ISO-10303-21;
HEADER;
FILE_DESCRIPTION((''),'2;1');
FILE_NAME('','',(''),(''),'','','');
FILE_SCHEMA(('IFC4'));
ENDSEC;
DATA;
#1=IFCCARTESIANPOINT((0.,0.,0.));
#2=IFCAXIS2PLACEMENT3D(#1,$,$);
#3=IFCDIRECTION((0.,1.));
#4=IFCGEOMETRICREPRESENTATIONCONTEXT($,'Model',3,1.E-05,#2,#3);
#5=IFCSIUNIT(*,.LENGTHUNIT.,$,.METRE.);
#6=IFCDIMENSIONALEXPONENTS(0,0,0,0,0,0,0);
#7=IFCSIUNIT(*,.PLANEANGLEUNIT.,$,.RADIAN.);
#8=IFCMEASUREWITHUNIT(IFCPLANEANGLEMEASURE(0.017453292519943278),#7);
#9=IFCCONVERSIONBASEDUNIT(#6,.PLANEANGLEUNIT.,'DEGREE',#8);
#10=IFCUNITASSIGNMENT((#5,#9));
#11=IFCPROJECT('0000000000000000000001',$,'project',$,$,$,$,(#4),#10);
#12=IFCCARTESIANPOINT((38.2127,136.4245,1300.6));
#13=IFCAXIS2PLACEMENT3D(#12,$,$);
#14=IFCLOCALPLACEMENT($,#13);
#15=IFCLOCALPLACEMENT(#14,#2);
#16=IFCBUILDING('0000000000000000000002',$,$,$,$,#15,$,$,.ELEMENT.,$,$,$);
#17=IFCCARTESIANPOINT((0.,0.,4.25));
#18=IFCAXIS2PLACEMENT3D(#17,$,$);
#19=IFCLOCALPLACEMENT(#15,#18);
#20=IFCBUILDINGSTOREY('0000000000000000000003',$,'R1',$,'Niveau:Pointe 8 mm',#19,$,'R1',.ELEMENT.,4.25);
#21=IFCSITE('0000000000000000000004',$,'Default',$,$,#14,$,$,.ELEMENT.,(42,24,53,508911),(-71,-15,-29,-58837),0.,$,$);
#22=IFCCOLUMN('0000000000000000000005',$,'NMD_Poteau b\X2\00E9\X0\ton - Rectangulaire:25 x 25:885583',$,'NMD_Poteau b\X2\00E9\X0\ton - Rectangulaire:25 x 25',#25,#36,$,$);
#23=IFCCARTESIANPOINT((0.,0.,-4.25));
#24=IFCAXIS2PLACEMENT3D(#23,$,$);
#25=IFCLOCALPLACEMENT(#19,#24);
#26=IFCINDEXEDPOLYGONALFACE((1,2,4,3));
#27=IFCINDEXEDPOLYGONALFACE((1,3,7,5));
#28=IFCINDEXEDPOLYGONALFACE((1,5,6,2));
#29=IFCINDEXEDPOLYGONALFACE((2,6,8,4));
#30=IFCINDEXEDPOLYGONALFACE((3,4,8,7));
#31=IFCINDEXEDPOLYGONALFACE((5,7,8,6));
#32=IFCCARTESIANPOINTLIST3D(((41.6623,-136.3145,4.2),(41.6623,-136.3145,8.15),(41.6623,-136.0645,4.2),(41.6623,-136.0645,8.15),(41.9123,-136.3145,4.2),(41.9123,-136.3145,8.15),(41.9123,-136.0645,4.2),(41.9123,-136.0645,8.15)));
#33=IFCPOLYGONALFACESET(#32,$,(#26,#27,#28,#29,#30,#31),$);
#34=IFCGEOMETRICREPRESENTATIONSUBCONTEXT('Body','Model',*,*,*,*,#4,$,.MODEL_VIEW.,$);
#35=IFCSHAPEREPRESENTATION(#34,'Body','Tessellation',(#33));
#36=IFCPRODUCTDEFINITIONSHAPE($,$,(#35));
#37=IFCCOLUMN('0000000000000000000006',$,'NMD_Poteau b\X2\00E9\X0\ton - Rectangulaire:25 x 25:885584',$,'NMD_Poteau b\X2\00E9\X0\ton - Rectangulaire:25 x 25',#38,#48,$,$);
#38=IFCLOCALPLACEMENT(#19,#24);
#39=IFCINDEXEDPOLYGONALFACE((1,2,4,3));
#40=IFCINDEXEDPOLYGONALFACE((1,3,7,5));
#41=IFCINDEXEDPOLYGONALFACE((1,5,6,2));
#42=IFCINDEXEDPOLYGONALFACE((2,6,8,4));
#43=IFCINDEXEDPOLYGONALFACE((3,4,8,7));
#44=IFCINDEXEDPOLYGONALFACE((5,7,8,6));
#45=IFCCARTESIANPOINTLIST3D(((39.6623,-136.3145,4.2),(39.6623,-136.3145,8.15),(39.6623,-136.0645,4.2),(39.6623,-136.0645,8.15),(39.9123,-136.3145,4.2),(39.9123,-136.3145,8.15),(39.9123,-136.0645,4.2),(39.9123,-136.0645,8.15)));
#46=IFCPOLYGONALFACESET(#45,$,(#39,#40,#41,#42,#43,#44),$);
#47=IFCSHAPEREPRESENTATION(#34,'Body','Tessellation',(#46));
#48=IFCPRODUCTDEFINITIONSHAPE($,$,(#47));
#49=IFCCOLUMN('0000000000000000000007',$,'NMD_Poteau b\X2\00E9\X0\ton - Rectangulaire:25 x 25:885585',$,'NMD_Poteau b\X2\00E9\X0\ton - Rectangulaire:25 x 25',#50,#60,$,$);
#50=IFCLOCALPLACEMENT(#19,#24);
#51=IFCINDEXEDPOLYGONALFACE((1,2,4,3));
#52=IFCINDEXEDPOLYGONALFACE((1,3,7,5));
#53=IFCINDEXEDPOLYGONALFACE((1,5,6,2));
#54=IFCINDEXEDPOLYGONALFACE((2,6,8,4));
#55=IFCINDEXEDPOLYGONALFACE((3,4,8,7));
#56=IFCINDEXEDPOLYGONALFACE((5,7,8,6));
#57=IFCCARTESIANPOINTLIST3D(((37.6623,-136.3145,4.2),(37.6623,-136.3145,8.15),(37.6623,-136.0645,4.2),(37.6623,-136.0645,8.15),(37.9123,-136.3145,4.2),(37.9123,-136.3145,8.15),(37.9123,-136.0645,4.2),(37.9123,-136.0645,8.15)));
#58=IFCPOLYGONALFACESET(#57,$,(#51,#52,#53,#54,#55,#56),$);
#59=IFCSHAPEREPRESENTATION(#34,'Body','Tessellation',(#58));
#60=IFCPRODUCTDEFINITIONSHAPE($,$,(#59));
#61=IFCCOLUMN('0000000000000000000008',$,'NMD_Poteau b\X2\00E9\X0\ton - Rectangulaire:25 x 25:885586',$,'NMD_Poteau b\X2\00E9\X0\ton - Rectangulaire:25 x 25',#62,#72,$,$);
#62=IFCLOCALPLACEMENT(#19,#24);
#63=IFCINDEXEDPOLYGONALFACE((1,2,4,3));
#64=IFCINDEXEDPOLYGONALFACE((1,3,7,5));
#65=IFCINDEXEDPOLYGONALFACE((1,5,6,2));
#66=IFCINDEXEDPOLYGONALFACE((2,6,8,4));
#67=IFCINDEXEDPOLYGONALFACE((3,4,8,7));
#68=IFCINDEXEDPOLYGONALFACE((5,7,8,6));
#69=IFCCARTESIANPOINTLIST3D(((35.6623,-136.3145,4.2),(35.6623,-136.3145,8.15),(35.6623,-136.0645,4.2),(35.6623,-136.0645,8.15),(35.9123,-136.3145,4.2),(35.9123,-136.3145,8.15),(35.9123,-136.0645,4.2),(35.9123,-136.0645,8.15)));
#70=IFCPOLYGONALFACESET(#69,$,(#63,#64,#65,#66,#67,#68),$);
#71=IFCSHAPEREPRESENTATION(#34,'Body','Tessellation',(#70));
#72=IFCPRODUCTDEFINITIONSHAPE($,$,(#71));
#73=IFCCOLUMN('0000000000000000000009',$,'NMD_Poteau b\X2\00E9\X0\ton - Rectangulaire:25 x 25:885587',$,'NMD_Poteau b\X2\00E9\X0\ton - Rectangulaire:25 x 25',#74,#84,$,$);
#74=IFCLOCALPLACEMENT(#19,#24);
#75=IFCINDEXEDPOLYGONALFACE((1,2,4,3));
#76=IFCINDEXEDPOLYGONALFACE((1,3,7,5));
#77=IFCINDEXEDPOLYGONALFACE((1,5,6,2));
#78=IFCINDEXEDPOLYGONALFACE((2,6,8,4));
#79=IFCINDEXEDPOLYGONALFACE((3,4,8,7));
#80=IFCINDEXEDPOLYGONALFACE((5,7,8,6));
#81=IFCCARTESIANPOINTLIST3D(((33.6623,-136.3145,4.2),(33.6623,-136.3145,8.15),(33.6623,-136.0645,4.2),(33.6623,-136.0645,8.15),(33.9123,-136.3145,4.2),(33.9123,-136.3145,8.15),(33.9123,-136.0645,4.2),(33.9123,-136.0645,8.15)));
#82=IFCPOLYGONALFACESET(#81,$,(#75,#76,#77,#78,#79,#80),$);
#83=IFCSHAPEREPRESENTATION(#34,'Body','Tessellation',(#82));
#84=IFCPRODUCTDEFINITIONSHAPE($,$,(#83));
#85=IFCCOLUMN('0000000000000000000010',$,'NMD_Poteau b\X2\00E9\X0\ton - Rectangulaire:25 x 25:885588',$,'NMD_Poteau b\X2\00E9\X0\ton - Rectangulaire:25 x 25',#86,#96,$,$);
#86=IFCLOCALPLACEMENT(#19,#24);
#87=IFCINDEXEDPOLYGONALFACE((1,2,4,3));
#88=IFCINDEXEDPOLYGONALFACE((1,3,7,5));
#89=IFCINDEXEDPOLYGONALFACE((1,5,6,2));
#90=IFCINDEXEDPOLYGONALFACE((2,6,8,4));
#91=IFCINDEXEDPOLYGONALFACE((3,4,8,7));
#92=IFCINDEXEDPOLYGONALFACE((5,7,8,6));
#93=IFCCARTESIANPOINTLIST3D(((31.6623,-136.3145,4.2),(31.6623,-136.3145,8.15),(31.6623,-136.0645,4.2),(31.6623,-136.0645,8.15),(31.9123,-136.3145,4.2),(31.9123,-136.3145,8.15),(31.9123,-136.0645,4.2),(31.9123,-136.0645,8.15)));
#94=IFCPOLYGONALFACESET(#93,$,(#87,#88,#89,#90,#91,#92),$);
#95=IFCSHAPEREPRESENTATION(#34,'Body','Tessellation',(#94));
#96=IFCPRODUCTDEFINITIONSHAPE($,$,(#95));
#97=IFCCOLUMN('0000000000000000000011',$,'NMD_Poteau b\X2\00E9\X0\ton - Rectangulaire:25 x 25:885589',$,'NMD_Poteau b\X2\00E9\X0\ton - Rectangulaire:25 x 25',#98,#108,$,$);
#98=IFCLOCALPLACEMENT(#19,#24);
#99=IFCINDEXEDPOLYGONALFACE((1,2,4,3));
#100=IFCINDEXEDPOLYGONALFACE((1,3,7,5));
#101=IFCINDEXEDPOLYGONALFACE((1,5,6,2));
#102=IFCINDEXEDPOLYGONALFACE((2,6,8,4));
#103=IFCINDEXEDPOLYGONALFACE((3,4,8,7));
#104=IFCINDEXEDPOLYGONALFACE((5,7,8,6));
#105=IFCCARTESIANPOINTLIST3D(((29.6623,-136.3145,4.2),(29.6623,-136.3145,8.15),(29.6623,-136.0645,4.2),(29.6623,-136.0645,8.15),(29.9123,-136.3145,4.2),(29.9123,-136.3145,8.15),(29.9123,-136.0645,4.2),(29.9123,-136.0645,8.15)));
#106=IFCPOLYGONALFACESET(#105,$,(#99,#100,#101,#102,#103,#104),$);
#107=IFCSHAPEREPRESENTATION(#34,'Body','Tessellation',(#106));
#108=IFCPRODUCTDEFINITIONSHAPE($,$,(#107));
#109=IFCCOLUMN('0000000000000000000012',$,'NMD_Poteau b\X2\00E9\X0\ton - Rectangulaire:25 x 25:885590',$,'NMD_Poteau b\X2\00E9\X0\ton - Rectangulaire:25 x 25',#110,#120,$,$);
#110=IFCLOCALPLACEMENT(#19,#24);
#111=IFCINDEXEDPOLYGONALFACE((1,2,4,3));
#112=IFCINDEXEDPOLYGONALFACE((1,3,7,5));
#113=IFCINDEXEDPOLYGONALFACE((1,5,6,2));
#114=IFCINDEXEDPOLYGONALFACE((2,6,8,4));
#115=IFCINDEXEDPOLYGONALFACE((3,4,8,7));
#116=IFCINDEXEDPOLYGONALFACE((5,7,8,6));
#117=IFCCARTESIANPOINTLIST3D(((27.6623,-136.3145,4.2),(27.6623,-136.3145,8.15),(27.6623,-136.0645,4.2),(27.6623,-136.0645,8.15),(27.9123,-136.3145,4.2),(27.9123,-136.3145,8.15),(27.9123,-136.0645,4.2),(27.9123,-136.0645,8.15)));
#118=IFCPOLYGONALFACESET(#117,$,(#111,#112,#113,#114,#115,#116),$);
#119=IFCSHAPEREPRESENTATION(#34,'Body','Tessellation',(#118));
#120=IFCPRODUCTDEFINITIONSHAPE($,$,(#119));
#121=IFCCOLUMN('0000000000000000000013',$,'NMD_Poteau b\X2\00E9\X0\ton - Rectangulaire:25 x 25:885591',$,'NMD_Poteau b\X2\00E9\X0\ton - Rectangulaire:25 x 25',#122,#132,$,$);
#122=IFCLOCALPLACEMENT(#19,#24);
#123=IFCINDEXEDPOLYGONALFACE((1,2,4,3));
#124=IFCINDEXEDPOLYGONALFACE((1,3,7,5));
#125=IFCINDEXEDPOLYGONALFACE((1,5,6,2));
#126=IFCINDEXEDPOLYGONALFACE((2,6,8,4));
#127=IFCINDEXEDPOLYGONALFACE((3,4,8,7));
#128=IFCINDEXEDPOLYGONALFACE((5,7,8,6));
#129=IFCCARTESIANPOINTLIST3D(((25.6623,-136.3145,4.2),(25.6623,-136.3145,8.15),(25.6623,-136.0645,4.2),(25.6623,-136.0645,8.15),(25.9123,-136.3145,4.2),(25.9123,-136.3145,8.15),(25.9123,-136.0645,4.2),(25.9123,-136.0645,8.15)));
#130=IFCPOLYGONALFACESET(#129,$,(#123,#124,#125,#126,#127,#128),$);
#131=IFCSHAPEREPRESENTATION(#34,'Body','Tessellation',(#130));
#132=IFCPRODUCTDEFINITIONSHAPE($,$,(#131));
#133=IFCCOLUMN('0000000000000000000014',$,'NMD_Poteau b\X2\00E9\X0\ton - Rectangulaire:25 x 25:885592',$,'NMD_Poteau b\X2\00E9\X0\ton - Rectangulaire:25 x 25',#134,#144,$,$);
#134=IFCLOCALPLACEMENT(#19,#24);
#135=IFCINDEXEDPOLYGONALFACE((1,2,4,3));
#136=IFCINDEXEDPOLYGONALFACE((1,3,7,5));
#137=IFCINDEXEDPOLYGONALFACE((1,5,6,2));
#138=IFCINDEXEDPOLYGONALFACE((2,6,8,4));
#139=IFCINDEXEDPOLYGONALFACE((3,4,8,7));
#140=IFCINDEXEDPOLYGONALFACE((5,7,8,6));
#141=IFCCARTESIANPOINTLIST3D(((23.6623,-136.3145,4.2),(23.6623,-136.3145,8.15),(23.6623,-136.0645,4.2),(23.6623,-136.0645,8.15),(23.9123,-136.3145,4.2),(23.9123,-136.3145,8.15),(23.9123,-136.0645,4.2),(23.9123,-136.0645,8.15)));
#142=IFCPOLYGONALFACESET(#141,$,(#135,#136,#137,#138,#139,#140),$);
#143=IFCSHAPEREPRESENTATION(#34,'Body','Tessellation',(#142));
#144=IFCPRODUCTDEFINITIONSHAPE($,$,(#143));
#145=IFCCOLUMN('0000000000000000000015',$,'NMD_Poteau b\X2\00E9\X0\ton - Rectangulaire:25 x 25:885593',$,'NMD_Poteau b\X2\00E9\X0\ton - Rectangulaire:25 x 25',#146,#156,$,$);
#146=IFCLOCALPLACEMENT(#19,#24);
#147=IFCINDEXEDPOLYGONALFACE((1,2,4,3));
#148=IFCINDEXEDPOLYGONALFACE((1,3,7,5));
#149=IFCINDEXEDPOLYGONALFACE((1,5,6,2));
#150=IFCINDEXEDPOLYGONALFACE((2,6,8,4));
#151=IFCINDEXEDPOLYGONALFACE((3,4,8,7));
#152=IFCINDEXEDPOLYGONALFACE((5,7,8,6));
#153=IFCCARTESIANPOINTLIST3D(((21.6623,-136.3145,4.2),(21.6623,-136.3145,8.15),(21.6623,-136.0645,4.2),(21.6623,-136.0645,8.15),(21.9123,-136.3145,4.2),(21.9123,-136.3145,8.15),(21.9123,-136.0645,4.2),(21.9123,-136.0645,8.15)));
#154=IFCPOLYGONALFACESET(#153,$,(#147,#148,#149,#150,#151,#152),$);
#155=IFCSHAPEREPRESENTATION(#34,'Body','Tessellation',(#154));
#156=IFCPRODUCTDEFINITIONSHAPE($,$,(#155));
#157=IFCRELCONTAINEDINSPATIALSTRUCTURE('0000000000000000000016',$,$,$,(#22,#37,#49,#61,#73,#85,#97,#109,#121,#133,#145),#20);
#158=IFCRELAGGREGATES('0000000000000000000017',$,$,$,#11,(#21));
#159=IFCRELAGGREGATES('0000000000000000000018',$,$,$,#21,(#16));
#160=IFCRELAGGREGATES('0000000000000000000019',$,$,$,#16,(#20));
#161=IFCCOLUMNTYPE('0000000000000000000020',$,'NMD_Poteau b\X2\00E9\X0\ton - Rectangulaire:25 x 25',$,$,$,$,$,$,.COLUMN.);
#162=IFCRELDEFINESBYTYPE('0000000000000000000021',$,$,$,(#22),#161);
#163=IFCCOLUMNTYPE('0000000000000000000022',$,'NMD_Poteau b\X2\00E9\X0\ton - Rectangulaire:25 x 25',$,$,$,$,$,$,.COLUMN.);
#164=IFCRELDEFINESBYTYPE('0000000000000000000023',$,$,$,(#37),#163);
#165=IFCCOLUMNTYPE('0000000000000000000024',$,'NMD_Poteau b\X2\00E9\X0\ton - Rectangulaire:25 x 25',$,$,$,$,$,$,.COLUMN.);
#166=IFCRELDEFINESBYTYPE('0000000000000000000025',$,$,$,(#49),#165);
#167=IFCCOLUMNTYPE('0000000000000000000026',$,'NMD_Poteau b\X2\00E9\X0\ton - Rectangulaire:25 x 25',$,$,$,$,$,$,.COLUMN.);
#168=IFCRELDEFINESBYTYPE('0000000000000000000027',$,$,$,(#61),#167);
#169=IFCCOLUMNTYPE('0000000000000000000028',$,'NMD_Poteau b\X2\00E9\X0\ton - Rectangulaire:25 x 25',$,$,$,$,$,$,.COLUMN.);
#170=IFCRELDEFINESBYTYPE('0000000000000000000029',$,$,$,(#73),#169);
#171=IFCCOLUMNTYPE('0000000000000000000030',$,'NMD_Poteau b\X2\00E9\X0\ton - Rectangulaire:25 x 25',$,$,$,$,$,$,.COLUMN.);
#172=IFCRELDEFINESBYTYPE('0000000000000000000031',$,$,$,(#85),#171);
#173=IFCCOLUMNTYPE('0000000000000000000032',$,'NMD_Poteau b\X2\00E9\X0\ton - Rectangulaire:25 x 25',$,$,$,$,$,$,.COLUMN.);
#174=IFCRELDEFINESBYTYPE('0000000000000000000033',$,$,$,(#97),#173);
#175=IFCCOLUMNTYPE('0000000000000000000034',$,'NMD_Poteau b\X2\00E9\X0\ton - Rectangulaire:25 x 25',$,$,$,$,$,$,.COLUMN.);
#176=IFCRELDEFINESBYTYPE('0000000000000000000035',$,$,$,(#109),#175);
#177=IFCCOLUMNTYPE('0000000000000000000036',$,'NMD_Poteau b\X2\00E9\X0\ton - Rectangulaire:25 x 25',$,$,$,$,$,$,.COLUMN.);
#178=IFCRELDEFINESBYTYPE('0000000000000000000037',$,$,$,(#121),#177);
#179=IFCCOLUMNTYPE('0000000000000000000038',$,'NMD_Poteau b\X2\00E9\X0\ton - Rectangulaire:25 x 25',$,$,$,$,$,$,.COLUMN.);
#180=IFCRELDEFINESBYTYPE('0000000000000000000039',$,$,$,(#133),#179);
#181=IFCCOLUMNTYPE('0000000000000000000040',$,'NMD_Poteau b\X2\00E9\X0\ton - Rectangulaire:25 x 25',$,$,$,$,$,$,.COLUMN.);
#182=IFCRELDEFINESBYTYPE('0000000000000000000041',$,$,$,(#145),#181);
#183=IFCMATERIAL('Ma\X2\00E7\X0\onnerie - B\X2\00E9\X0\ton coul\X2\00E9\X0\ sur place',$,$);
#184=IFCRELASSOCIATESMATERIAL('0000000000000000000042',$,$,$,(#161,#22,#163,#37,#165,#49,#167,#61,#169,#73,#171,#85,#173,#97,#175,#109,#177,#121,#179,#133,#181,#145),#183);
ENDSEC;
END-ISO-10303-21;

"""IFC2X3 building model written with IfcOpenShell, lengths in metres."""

from ifc_helpers import new_model, entity, si_unit, converted_unit, direction, frame, frame_2d, origin, place, context, subcontext, project, spatial, rectangle, extrude, source, transform, mapped, material, type_object, type_shapes, element, save


model = new_model("IFC2X3")

# Units and contexts
model_context = context("Model", 3, precision=1e-05, world=origin(), true_north=direction((0.0, 1.0)))
body_context = subcontext(model_context, "Body", "Model", "MODEL_VIEW")
ifc_project = project(units=[si_unit("LENGTHUNIT", "METRE"), converted_unit("PLANEANGLEUNIT", "DEGREE", entity("IfcPlaneAngleMeasure", 0.017453292519943278), si_unit("PLANEANGLEUNIT", "RADIAN"), dimensions=[0, 0, 0, 0, 0, 0, 0])], contexts=[model_context])

# Site, building, storey
site_placement = place(None, frame((38.2127, 136.4245, 1300.6)))
site = spatial("IfcSite", under=ifc_project, at=site_placement, Name="Default", CompositionType="ELEMENT", RefLatitude=(42, 24, 53, 508911), RefLongitude=(-71, -15, -29, -58837), RefElevation=0.0)
building_placement = place(site_placement, origin())
building = spatial("IfcBuilding", under=site, at=building_placement, CompositionType="ELEMENT")
storey_placement = place(building_placement, frame((0.0, 0.0, 4.25)))
storey = spatial("IfcBuildingStorey", under=building, at=storey_placement, Name="R1", ObjectType="Niveau:Pointe 8 mm", LongName="R1", CompositionType="ELEMENT", Elevation=4.25)

# Columns
ifc_material = material(Name="Maçonnerie - Béton coulé sur place")
column_type_1 = type_object("IfcColumnType", Name="NMD_Poteau béton - Rectangulaire:25 x 25", PredefinedType="COLUMN", material=ifc_material)
shared_shape_1 = source(origin(), body_context, "Body", "SweptSolid", [
    extrude(rectangle(XDim=0.25, YDim=0.25, at=frame_2d((0.0, 0.0), x_axis=(1.0, 0.0))), frame((41.7873, -136.1895, 4.2), z_axis=(0.0, 0.0, 1.0), x_axis=(-1.0, 0.0, 0.0)), (0.0, 0.0, 1.0), 3.95),
])
type_shapes(column_type_1, [shared_shape_1])
column_1_placement = place(storey_placement, frame((0.0, 0.0, -4.25)))
element("IfcColumn", 1, at=column_1_placement, inside=storey, type_object=column_type_1, material=ifc_material, Name="NMD_Poteau béton - Rectangulaire:25 x 25:885583", ObjectType="NMD_Poteau béton - Rectangulaire:25 x 25", context=body_context, shape_type="MappedRepresentation", body=[
    mapped(shared_shape_1, transform((0.0, 0.0, 0.0), scale=1.0)),
])
column_type_2 = type_object("IfcColumnType", Name="NMD_Poteau béton - Rectangulaire:25 x 25", PredefinedType="COLUMN", material=ifc_material)
shared_shape_2 = source(origin(), body_context, "Body", "SweptSolid", [
    extrude(rectangle(XDim=0.25, YDim=0.25, at=frame_2d((0.0, 0.0), x_axis=(1.0, 0.0))), frame((39.7873, -136.1895, 4.2), z_axis=(0.0, 0.0, 1.0), x_axis=(-1.0, 0.0, 0.0)), (0.0, 0.0, 1.0), 3.95),
])
type_shapes(column_type_2, [shared_shape_2])
column_2_placement = place(storey_placement, frame((0.0, 0.0, -4.25)))
element("IfcColumn", 2, at=column_2_placement, inside=storey, type_object=column_type_2, material=ifc_material, Name="NMD_Poteau béton - Rectangulaire:25 x 25:885584", ObjectType="NMD_Poteau béton - Rectangulaire:25 x 25", context=body_context, shape_type="MappedRepresentation", body=[
    mapped(shared_shape_2, transform((0.0, 0.0, 0.0), scale=1.0)),
])
column_type_3 = type_object("IfcColumnType", Name="NMD_Poteau béton - Rectangulaire:25 x 25", PredefinedType="COLUMN", material=ifc_material)
shared_shape_3 = source(origin(), body_context, "Body", "SweptSolid", [
    extrude(rectangle(XDim=0.25, YDim=0.25, at=frame_2d((0.0, 0.0), x_axis=(1.0, 0.0))), frame((37.7873, -136.1895, 4.2), z_axis=(0.0, 0.0, 1.0), x_axis=(-1.0, 0.0, 0.0)), (0.0, 0.0, 1.0), 3.95),
])
type_shapes(column_type_3, [shared_shape_3])
column_3_placement = place(storey_placement, frame((0.0, 0.0, -4.25)))
element("IfcColumn", 3, at=column_3_placement, inside=storey, type_object=column_type_3, material=ifc_material, Name="NMD_Poteau béton - Rectangulaire:25 x 25:885585", ObjectType="NMD_Poteau béton - Rectangulaire:25 x 25", context=body_context, shape_type="MappedRepresentation", body=[
    mapped(shared_shape_3, transform((0.0, 0.0, 0.0), scale=1.0)),
])
column_type_4 = type_object("IfcColumnType", Name="NMD_Poteau béton - Rectangulaire:25 x 25", PredefinedType="COLUMN", material=ifc_material)
shared_shape_4 = source(origin(), body_context, "Body", "SweptSolid", [
    extrude(rectangle(XDim=0.25, YDim=0.25, at=frame_2d((0.0, 0.0), x_axis=(1.0, 0.0))), frame((35.7873, -136.1895, 4.2), z_axis=(0.0, 0.0, 1.0), x_axis=(-1.0, 0.0, 0.0)), (0.0, 0.0, 1.0), 3.95),
])
type_shapes(column_type_4, [shared_shape_4])
column_4_placement = place(storey_placement, frame((0.0, 0.0, -4.25)))
element("IfcColumn", 4, at=column_4_placement, inside=storey, type_object=column_type_4, material=ifc_material, Name="NMD_Poteau béton - Rectangulaire:25 x 25:885586", ObjectType="NMD_Poteau béton - Rectangulaire:25 x 25", context=body_context, shape_type="MappedRepresentation", body=[
    mapped(shared_shape_4, transform((0.0, 0.0, 0.0), scale=1.0)),
])
column_type_5 = type_object("IfcColumnType", Name="NMD_Poteau béton - Rectangulaire:25 x 25", PredefinedType="COLUMN", material=ifc_material)
shared_shape_5 = source(origin(), body_context, "Body", "SweptSolid", [
    extrude(rectangle(XDim=0.25, YDim=0.25, at=frame_2d((0.0, 0.0), x_axis=(1.0, 0.0))), frame((33.7873, -136.1895, 4.2), z_axis=(0.0, 0.0, 1.0), x_axis=(-1.0, 0.0, 0.0)), (0.0, 0.0, 1.0), 3.95),
])
type_shapes(column_type_5, [shared_shape_5])
column_5_placement = place(storey_placement, frame((0.0, 0.0, -4.25)))
element("IfcColumn", 5, at=column_5_placement, inside=storey, type_object=column_type_5, material=ifc_material, Name="NMD_Poteau béton - Rectangulaire:25 x 25:885587", ObjectType="NMD_Poteau béton - Rectangulaire:25 x 25", context=body_context, shape_type="MappedRepresentation", body=[
    mapped(shared_shape_5, transform((0.0, 0.0, 0.0), scale=1.0)),
])
column_type_6 = type_object("IfcColumnType", Name="NMD_Poteau béton - Rectangulaire:25 x 25", PredefinedType="COLUMN", material=ifc_material)
shared_shape_6 = source(origin(), body_context, "Body", "SweptSolid", [
    extrude(rectangle(XDim=0.25, YDim=0.25, at=frame_2d((0.0, 0.0), x_axis=(1.0, 0.0))), frame((31.7873, -136.1895, 4.2), z_axis=(0.0, 0.0, 1.0), x_axis=(-1.0, 0.0, 0.0)), (0.0, 0.0, 1.0), 3.95),
])
type_shapes(column_type_6, [shared_shape_6])
column_6_placement = place(storey_placement, frame((0.0, 0.0, -4.25)))
element("IfcColumn", 6, at=column_6_placement, inside=storey, type_object=column_type_6, material=ifc_material, Name="NMD_Poteau béton - Rectangulaire:25 x 25:885588", ObjectType="NMD_Poteau béton - Rectangulaire:25 x 25", context=body_context, shape_type="MappedRepresentation", body=[
    mapped(shared_shape_6, transform((0.0, 0.0, 0.0), scale=1.0)),
])
column_type_7 = type_object("IfcColumnType", Name="NMD_Poteau béton - Rectangulaire:25 x 25", PredefinedType="COLUMN", material=ifc_material)
shared_shape_7 = source(origin(), body_context, "Body", "SweptSolid", [
    extrude(rectangle(XDim=0.25, YDim=0.25, at=frame_2d((0.0, 0.0), x_axis=(1.0, 0.0))), frame((29.7873, -136.1895, 4.2), z_axis=(0.0, 0.0, 1.0), x_axis=(-1.0, 0.0, 0.0)), (0.0, 0.0, 1.0), 3.95),
])
type_shapes(column_type_7, [shared_shape_7])
column_7_placement = place(storey_placement, frame((0.0, 0.0, -4.25)))
element("IfcColumn", 7, at=column_7_placement, inside=storey, type_object=column_type_7, material=ifc_material, Name="NMD_Poteau béton - Rectangulaire:25 x 25:885589", ObjectType="NMD_Poteau béton - Rectangulaire:25 x 25", context=body_context, shape_type="MappedRepresentation", body=[
    mapped(shared_shape_7, transform((0.0, 0.0, 0.0), scale=1.0)),
])
column_type_8 = type_object("IfcColumnType", Name="NMD_Poteau béton - Rectangulaire:25 x 25", PredefinedType="COLUMN", material=ifc_material)
shared_shape_8 = source(origin(), body_context, "Body", "SweptSolid", [
    extrude(rectangle(XDim=0.25, YDim=0.25, at=frame_2d((0.0, 0.0), x_axis=(1.0, 0.0))), frame((27.7873, -136.1895, 4.2), z_axis=(0.0, 0.0, 1.0), x_axis=(-1.0, 0.0, 0.0)), (0.0, 0.0, 1.0), 3.95),
])
type_shapes(column_type_8, [shared_shape_8])
column_8_placement = place(storey_placement, frame((0.0, 0.0, -4.25)))
element("IfcColumn", 8, at=column_8_placement, inside=storey, type_object=column_type_8, material=ifc_material, Name="NMD_Poteau béton - Rectangulaire:25 x 25:885590", ObjectType="NMD_Poteau béton - Rectangulaire:25 x 25", context=body_context, shape_type="MappedRepresentation", body=[
    mapped(shared_shape_8, transform((0.0, 0.0, 0.0), scale=1.0)),
])
column_type_9 = type_object("IfcColumnType", Name="NMD_Poteau béton - Rectangulaire:25 x 25", PredefinedType="COLUMN", material=ifc_material)
shared_shape_9 = source(origin(), body_context, "Body", "SweptSolid", [
    extrude(rectangle(XDim=0.25, YDim=0.25, at=frame_2d((0.0, 0.0), x_axis=(1.0, 0.0))), frame((25.7873, -136.1895, 4.2), z_axis=(0.0, 0.0, 1.0), x_axis=(-1.0, 0.0, 0.0)), (0.0, 0.0, 1.0), 3.95),
])
type_shapes(column_type_9, [shared_shape_9])
column_9_placement = place(storey_placement, frame((0.0, 0.0, -4.25)))
element("IfcColumn", 9, at=column_9_placement, inside=storey, type_object=column_type_9, material=ifc_material, Name="NMD_Poteau béton - Rectangulaire:25 x 25:885591", ObjectType="NMD_Poteau béton - Rectangulaire:25 x 25", context=body_context, shape_type="MappedRepresentation", body=[
    mapped(shared_shape_9, transform((0.0, 0.0, 0.0), scale=1.0)),
])
column_type_10 = type_object("IfcColumnType", Name="NMD_Poteau béton - Rectangulaire:25 x 25", PredefinedType="COLUMN", material=ifc_material)
shared_shape_10 = source(origin(), body_context, "Body", "SweptSolid", [
    extrude(rectangle(XDim=0.25, YDim=0.25, at=frame_2d((0.0, 0.0), x_axis=(1.0, 0.0))), frame((23.7873, -136.1895, 4.2), z_axis=(0.0, 0.0, 1.0), x_axis=(-1.0, 0.0, 0.0)), (0.0, 0.0, 1.0), 3.95),
])
type_shapes(column_type_10, [shared_shape_10])
column_10_placement = place(storey_placement, frame((0.0, 0.0, -4.25)))
element("IfcColumn", 10, at=column_10_placement, inside=storey, type_object=column_type_10, material=ifc_material, Name="NMD_Poteau béton - Rectangulaire:25 x 25:885592", ObjectType="NMD_Poteau béton - Rectangulaire:25 x 25", context=body_context, shape_type="MappedRepresentation", body=[
    mapped(shared_shape_10, transform((0.0, 0.0, 0.0), scale=1.0)),
])
column_type_11 = type_object("IfcColumnType", Name="NMD_Poteau béton - Rectangulaire:25 x 25", PredefinedType="COLUMN", material=ifc_material)
shared_shape_11 = source(origin(), body_context, "Body", "SweptSolid", [
    extrude(rectangle(XDim=0.25, YDim=0.25, at=frame_2d((0.0, 0.0), x_axis=(1.0, 0.0))), frame((21.7873, -136.1895, 4.2), z_axis=(0.0, 0.0, 1.0), x_axis=(-1.0, 0.0, 0.0)), (0.0, 0.0, 1.0), 3.95),
])
type_shapes(column_type_11, [shared_shape_11])
column_11_placement = place(storey_placement, frame((0.0, 0.0, -4.25)))
element("IfcColumn", 11, at=column_11_placement, inside=storey, type_object=column_type_11, material=ifc_material, Name="NMD_Poteau béton - Rectangulaire:25 x 25:885593", ObjectType="NMD_Poteau béton - Rectangulaire:25 x 25", context=body_context, shape_type="MappedRepresentation", body=[
    mapped(shared_shape_11, transform((0.0, 0.0, 0.0), scale=1.0)),
])

save(model, "model.ifc")
